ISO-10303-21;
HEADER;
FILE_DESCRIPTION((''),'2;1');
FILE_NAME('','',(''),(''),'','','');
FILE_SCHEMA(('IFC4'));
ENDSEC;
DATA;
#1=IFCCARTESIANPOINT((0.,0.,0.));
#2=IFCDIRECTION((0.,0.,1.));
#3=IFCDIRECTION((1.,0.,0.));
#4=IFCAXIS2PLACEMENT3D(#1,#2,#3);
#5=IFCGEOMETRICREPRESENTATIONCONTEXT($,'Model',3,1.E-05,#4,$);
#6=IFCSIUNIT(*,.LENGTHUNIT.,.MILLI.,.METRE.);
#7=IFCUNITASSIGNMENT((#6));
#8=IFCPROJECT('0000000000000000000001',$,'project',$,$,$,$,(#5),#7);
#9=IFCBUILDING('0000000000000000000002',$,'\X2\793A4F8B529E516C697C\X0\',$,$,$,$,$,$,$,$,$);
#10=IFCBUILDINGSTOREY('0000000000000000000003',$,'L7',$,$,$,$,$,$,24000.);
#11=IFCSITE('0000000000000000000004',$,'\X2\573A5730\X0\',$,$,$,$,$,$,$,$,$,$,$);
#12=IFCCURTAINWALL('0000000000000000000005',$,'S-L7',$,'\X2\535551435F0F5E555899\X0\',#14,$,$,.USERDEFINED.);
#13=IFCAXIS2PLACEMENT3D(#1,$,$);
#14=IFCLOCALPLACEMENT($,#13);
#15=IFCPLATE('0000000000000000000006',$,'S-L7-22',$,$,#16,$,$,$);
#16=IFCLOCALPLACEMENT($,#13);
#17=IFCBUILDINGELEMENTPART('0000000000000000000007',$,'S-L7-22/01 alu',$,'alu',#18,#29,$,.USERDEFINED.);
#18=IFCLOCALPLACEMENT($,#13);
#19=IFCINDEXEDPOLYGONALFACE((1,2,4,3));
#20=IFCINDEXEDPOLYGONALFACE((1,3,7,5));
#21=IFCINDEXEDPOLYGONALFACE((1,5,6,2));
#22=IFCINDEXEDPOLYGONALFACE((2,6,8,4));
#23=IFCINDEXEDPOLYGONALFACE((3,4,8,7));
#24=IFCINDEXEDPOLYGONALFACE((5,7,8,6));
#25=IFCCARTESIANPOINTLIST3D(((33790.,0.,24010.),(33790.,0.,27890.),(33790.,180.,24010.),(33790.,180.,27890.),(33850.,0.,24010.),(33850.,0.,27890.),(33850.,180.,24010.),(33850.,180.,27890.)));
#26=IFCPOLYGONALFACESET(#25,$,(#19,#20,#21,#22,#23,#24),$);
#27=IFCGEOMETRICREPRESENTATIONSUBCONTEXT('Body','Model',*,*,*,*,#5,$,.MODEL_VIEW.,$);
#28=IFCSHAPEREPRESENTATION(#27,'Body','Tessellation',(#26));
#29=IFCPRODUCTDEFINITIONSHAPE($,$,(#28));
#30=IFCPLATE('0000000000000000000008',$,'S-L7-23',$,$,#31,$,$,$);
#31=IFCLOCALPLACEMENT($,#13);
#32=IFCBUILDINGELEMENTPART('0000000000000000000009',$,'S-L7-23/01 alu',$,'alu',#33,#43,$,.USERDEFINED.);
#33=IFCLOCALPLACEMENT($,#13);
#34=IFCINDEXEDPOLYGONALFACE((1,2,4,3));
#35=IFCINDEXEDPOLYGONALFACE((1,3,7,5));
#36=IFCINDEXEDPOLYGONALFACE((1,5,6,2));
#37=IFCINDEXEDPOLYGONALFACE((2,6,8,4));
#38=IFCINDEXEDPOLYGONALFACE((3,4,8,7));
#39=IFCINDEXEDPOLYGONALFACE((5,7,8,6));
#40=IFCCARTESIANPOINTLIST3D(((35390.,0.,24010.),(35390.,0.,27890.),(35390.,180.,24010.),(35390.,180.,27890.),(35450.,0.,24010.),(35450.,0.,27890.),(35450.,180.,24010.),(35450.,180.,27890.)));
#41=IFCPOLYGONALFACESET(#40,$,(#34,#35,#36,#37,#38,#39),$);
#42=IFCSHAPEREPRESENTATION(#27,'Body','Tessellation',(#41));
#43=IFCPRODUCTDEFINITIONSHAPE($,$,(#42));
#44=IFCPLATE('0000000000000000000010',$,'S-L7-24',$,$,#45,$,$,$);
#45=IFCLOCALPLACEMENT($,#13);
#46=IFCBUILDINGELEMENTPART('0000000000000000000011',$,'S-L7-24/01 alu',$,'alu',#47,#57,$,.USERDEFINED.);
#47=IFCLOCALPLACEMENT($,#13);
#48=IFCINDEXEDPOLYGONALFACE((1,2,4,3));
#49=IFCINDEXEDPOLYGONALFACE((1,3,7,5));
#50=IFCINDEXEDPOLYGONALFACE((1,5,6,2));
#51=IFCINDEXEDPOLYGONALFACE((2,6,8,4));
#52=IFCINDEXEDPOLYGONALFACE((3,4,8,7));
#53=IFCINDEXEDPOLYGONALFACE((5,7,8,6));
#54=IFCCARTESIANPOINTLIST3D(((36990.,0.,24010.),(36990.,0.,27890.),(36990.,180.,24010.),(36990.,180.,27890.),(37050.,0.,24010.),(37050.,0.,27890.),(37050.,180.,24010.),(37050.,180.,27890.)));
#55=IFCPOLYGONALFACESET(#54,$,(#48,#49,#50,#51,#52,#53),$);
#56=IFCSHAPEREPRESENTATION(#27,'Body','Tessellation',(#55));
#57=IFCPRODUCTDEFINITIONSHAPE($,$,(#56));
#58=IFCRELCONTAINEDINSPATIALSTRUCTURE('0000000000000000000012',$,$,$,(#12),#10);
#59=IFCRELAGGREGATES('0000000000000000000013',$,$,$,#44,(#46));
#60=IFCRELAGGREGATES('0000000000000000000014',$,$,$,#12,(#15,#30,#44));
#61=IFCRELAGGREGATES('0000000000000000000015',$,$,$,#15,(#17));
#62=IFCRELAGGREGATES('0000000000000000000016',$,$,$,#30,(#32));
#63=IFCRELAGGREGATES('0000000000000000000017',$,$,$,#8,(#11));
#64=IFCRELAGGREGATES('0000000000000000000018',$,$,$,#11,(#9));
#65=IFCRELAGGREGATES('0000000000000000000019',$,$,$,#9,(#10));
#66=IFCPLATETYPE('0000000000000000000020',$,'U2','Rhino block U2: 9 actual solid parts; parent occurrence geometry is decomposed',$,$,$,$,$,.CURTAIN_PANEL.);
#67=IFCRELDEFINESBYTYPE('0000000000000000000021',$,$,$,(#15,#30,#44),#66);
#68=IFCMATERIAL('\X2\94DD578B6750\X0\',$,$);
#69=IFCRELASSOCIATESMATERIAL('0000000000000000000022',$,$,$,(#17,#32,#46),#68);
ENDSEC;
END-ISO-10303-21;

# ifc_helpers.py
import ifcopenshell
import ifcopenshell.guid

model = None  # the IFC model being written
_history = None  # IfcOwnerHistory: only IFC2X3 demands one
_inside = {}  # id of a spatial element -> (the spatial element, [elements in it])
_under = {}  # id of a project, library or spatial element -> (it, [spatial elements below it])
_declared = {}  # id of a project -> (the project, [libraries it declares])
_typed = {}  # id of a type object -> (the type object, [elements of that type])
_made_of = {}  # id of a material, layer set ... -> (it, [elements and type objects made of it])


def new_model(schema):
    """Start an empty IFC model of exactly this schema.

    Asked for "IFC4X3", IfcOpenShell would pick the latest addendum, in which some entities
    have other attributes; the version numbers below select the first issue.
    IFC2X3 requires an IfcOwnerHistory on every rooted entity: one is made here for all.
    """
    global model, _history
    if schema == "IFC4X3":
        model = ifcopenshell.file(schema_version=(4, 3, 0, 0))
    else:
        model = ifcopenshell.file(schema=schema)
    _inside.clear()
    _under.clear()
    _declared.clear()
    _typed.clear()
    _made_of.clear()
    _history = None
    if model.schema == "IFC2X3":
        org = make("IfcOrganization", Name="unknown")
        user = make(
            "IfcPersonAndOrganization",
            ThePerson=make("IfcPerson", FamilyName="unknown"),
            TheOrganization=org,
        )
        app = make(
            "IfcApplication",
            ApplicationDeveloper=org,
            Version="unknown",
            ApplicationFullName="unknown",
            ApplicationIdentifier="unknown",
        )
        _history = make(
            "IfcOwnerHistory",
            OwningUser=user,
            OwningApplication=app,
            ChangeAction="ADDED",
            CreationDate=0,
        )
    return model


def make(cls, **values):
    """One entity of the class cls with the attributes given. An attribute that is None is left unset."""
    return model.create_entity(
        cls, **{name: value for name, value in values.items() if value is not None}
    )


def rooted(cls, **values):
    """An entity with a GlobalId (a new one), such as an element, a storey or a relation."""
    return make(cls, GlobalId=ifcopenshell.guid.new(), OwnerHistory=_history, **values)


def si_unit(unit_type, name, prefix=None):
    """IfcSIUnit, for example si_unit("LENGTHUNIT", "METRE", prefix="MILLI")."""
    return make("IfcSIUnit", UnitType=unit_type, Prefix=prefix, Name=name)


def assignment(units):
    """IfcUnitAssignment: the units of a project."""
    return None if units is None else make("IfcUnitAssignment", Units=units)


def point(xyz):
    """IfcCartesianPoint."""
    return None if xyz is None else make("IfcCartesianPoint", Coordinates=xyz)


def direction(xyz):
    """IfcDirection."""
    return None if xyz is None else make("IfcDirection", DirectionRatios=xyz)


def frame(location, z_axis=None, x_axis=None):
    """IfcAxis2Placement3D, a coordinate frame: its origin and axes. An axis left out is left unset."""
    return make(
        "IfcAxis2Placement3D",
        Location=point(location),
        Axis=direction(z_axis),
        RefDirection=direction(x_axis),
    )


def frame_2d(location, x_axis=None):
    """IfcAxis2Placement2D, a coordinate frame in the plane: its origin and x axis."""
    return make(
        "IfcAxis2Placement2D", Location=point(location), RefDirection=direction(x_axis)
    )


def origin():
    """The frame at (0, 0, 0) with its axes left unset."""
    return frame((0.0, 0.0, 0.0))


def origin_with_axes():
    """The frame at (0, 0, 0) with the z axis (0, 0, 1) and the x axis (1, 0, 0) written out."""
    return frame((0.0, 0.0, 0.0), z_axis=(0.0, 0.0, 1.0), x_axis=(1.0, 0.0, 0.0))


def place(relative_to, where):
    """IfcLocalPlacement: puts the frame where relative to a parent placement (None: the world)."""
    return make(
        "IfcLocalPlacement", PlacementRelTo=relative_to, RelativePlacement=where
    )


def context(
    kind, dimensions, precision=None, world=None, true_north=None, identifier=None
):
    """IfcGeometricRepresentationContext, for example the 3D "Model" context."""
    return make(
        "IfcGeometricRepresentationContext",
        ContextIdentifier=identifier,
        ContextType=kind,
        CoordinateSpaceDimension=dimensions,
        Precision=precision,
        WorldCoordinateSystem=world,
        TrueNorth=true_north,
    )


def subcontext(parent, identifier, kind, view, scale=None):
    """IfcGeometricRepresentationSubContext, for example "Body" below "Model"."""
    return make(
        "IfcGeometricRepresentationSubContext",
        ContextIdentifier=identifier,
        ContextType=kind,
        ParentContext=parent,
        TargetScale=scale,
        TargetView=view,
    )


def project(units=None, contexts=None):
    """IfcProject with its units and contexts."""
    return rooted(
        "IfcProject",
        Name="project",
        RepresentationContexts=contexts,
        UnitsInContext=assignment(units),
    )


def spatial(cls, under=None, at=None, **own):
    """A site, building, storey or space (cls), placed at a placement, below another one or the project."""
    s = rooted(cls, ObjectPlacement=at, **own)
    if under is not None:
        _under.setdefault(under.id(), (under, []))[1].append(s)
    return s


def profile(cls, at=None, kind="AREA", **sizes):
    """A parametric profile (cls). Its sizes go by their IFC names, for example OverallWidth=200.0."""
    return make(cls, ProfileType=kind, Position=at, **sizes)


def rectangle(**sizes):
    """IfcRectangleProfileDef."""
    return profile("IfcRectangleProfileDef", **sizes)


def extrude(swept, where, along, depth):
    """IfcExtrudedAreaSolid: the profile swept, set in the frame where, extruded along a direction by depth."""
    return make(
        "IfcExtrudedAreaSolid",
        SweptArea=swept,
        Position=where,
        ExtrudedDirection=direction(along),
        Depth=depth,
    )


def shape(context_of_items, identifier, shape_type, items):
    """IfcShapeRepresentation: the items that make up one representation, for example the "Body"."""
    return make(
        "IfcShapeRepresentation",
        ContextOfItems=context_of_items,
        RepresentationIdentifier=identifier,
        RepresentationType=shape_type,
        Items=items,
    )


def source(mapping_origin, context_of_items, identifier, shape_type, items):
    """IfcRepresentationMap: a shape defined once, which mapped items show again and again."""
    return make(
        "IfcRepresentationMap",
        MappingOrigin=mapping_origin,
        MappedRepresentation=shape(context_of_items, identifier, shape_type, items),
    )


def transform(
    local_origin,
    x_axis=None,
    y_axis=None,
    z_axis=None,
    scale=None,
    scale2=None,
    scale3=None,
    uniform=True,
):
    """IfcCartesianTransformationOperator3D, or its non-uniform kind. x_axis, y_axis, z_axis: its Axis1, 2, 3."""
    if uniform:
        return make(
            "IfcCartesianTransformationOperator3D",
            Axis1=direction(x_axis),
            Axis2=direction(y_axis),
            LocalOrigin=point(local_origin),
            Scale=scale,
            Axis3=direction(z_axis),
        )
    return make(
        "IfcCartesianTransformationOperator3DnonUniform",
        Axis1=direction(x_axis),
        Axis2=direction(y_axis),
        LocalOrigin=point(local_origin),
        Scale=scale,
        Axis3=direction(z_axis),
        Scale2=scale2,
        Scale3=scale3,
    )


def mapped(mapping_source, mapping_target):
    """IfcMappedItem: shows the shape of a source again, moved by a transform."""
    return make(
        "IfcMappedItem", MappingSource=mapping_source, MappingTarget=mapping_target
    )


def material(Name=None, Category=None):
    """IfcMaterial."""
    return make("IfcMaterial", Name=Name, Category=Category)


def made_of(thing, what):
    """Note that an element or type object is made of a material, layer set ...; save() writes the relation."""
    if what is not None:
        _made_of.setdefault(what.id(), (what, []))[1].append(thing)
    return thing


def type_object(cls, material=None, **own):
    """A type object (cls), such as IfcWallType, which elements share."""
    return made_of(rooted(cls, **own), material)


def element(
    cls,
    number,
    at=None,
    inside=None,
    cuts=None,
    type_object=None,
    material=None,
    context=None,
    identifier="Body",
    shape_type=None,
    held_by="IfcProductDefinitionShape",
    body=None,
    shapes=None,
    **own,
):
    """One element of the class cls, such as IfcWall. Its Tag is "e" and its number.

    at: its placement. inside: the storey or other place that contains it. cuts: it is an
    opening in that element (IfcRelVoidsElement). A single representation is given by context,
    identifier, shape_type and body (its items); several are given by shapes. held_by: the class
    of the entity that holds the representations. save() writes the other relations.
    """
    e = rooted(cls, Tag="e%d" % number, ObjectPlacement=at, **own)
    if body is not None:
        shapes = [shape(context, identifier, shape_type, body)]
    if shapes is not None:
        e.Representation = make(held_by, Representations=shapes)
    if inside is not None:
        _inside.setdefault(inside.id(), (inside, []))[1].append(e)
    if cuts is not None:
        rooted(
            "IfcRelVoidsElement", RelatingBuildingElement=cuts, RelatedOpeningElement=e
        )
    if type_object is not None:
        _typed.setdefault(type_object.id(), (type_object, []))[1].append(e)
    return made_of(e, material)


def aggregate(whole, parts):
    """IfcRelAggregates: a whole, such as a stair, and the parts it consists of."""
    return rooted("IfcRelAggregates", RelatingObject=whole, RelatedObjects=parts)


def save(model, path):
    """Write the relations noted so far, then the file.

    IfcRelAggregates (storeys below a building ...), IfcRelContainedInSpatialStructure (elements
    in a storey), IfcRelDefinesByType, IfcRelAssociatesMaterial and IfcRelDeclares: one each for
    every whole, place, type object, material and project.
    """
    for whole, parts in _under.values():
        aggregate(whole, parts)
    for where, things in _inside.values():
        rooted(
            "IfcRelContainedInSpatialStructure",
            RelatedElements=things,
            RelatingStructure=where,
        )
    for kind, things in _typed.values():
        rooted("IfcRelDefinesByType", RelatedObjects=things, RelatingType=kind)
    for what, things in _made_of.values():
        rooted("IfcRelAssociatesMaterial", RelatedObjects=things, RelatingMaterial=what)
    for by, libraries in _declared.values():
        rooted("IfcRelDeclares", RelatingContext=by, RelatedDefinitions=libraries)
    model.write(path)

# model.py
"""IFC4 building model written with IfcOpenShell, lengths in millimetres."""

from ifc_helpers import new_model, si_unit, frame, frame_2d, origin, origin_with_axes, place, context, subcontext, project, spatial, rectangle, extrude, source, transform, mapped, material, type_object, element, aggregate, save


model = new_model("IFC4")

# Units and contexts
model_context = context("Model", 3, precision=1e-05, world=origin_with_axes())
body_context = subcontext(model_context, "Body", "Model", "MODEL_VIEW")
ifc_project = project(units=[si_unit("LENGTHUNIT", "METRE", prefix="MILLI")], contexts=[model_context])

# Site, building, storey
site = spatial("IfcSite", under=ifc_project, Name="场地")
building = spatial("IfcBuilding", under=site, Name="示例办公楼")
storey = spatial("IfcBuildingStorey", under=building, Name="L7", Elevation=24000.0)

# Curtain wall, plates, building element parts
curtain_wall = element("IfcCurtainWall", 1, inside=storey, Name="S-L7", ObjectType="单元式幕墙", PredefinedType="USERDEFINED")
plate_type = type_object("IfcPlateType", Name="U2", Description="Rhino block U2: 9 actual solid parts; parent occurrence geometry is decomposed", PredefinedType="CURTAIN_PANEL")
plate_1_placement = place(None, frame((33790.0, 0.0, 24010.0), z_axis=(0.0, 0.0, 1.0), x_axis=(1.0, 0.0, 0.0)))
plate_1 = element("IfcPlate", 2, at=plate_1_placement, type_object=plate_type, Name="S-L7-22")
ifc_material_1 = material(Name="铝型材")
shared_shape_1 = source(origin(), body_context, "Body", "SweptSolid", [
    extrude(rectangle(XDim=60.0, YDim=180.0, at=frame_2d((30.0, 90.0))), origin(), (0.0, 0.0, 1.0), 3880.0),
])
building_element_part_1_placement = place(plate_1_placement, origin())
building_element_part_1 = element("IfcBuildingElementPart", 3, at=building_element_part_1_placement, material=ifc_material_1, Name="S-L7-22/01 alu", ObjectType="alu", PredefinedType="USERDEFINED", context=body_context, shape_type="MappedRepresentation", body=[
    mapped(shared_shape_1, transform((0.0, 0.0, 0.0))),
])
plate_2_placement = place(None, frame((35390.0, 0.0, 24010.0), z_axis=(0.0, 0.0, 1.0), x_axis=(1.0, 0.0, 0.0)))
plate_2 = element("IfcPlate", 4, at=plate_2_placement, type_object=plate_type, Name="S-L7-23")
building_element_part_2_placement = place(plate_2_placement, origin())
building_element_part_2 = element("IfcBuildingElementPart", 5, at=building_element_part_2_placement, material=ifc_material_1, Name="S-L7-23/01 alu", ObjectType="alu", PredefinedType="USERDEFINED", context=body_context, shape_type="MappedRepresentation", body=[
    mapped(shared_shape_1, transform((0.0, 0.0, 0.0))),
])
plate_3_placement = place(None, frame((36990.0, 0.0, 24010.0), z_axis=(0.0, 0.0, 1.0), x_axis=(1.0, 0.0, 0.0)))
plate_3 = element("IfcPlate", 6, at=plate_3_placement, type_object=plate_type, Name="S-L7-24")
building_element_part_3_placement = place(plate_3_placement, origin())
building_element_part_3 = element("IfcBuildingElementPart", 7, at=building_element_part_3_placement, material=ifc_material_1, Name="S-L7-24/01 alu", ObjectType="alu", PredefinedType="USERDEFINED", context=body_context, shape_type="MappedRepresentation", body=[
    mapped(shared_shape_1, transform((0.0, 0.0, 0.0))),
])
aggregate(plate_3, [building_element_part_3])
aggregate(curtain_wall, [plate_1, plate_2, plate_3])
aggregate(plate_1, [building_element_part_1])
aggregate(plate_2, [building_element_part_2])

save(model, "model.ifc")
